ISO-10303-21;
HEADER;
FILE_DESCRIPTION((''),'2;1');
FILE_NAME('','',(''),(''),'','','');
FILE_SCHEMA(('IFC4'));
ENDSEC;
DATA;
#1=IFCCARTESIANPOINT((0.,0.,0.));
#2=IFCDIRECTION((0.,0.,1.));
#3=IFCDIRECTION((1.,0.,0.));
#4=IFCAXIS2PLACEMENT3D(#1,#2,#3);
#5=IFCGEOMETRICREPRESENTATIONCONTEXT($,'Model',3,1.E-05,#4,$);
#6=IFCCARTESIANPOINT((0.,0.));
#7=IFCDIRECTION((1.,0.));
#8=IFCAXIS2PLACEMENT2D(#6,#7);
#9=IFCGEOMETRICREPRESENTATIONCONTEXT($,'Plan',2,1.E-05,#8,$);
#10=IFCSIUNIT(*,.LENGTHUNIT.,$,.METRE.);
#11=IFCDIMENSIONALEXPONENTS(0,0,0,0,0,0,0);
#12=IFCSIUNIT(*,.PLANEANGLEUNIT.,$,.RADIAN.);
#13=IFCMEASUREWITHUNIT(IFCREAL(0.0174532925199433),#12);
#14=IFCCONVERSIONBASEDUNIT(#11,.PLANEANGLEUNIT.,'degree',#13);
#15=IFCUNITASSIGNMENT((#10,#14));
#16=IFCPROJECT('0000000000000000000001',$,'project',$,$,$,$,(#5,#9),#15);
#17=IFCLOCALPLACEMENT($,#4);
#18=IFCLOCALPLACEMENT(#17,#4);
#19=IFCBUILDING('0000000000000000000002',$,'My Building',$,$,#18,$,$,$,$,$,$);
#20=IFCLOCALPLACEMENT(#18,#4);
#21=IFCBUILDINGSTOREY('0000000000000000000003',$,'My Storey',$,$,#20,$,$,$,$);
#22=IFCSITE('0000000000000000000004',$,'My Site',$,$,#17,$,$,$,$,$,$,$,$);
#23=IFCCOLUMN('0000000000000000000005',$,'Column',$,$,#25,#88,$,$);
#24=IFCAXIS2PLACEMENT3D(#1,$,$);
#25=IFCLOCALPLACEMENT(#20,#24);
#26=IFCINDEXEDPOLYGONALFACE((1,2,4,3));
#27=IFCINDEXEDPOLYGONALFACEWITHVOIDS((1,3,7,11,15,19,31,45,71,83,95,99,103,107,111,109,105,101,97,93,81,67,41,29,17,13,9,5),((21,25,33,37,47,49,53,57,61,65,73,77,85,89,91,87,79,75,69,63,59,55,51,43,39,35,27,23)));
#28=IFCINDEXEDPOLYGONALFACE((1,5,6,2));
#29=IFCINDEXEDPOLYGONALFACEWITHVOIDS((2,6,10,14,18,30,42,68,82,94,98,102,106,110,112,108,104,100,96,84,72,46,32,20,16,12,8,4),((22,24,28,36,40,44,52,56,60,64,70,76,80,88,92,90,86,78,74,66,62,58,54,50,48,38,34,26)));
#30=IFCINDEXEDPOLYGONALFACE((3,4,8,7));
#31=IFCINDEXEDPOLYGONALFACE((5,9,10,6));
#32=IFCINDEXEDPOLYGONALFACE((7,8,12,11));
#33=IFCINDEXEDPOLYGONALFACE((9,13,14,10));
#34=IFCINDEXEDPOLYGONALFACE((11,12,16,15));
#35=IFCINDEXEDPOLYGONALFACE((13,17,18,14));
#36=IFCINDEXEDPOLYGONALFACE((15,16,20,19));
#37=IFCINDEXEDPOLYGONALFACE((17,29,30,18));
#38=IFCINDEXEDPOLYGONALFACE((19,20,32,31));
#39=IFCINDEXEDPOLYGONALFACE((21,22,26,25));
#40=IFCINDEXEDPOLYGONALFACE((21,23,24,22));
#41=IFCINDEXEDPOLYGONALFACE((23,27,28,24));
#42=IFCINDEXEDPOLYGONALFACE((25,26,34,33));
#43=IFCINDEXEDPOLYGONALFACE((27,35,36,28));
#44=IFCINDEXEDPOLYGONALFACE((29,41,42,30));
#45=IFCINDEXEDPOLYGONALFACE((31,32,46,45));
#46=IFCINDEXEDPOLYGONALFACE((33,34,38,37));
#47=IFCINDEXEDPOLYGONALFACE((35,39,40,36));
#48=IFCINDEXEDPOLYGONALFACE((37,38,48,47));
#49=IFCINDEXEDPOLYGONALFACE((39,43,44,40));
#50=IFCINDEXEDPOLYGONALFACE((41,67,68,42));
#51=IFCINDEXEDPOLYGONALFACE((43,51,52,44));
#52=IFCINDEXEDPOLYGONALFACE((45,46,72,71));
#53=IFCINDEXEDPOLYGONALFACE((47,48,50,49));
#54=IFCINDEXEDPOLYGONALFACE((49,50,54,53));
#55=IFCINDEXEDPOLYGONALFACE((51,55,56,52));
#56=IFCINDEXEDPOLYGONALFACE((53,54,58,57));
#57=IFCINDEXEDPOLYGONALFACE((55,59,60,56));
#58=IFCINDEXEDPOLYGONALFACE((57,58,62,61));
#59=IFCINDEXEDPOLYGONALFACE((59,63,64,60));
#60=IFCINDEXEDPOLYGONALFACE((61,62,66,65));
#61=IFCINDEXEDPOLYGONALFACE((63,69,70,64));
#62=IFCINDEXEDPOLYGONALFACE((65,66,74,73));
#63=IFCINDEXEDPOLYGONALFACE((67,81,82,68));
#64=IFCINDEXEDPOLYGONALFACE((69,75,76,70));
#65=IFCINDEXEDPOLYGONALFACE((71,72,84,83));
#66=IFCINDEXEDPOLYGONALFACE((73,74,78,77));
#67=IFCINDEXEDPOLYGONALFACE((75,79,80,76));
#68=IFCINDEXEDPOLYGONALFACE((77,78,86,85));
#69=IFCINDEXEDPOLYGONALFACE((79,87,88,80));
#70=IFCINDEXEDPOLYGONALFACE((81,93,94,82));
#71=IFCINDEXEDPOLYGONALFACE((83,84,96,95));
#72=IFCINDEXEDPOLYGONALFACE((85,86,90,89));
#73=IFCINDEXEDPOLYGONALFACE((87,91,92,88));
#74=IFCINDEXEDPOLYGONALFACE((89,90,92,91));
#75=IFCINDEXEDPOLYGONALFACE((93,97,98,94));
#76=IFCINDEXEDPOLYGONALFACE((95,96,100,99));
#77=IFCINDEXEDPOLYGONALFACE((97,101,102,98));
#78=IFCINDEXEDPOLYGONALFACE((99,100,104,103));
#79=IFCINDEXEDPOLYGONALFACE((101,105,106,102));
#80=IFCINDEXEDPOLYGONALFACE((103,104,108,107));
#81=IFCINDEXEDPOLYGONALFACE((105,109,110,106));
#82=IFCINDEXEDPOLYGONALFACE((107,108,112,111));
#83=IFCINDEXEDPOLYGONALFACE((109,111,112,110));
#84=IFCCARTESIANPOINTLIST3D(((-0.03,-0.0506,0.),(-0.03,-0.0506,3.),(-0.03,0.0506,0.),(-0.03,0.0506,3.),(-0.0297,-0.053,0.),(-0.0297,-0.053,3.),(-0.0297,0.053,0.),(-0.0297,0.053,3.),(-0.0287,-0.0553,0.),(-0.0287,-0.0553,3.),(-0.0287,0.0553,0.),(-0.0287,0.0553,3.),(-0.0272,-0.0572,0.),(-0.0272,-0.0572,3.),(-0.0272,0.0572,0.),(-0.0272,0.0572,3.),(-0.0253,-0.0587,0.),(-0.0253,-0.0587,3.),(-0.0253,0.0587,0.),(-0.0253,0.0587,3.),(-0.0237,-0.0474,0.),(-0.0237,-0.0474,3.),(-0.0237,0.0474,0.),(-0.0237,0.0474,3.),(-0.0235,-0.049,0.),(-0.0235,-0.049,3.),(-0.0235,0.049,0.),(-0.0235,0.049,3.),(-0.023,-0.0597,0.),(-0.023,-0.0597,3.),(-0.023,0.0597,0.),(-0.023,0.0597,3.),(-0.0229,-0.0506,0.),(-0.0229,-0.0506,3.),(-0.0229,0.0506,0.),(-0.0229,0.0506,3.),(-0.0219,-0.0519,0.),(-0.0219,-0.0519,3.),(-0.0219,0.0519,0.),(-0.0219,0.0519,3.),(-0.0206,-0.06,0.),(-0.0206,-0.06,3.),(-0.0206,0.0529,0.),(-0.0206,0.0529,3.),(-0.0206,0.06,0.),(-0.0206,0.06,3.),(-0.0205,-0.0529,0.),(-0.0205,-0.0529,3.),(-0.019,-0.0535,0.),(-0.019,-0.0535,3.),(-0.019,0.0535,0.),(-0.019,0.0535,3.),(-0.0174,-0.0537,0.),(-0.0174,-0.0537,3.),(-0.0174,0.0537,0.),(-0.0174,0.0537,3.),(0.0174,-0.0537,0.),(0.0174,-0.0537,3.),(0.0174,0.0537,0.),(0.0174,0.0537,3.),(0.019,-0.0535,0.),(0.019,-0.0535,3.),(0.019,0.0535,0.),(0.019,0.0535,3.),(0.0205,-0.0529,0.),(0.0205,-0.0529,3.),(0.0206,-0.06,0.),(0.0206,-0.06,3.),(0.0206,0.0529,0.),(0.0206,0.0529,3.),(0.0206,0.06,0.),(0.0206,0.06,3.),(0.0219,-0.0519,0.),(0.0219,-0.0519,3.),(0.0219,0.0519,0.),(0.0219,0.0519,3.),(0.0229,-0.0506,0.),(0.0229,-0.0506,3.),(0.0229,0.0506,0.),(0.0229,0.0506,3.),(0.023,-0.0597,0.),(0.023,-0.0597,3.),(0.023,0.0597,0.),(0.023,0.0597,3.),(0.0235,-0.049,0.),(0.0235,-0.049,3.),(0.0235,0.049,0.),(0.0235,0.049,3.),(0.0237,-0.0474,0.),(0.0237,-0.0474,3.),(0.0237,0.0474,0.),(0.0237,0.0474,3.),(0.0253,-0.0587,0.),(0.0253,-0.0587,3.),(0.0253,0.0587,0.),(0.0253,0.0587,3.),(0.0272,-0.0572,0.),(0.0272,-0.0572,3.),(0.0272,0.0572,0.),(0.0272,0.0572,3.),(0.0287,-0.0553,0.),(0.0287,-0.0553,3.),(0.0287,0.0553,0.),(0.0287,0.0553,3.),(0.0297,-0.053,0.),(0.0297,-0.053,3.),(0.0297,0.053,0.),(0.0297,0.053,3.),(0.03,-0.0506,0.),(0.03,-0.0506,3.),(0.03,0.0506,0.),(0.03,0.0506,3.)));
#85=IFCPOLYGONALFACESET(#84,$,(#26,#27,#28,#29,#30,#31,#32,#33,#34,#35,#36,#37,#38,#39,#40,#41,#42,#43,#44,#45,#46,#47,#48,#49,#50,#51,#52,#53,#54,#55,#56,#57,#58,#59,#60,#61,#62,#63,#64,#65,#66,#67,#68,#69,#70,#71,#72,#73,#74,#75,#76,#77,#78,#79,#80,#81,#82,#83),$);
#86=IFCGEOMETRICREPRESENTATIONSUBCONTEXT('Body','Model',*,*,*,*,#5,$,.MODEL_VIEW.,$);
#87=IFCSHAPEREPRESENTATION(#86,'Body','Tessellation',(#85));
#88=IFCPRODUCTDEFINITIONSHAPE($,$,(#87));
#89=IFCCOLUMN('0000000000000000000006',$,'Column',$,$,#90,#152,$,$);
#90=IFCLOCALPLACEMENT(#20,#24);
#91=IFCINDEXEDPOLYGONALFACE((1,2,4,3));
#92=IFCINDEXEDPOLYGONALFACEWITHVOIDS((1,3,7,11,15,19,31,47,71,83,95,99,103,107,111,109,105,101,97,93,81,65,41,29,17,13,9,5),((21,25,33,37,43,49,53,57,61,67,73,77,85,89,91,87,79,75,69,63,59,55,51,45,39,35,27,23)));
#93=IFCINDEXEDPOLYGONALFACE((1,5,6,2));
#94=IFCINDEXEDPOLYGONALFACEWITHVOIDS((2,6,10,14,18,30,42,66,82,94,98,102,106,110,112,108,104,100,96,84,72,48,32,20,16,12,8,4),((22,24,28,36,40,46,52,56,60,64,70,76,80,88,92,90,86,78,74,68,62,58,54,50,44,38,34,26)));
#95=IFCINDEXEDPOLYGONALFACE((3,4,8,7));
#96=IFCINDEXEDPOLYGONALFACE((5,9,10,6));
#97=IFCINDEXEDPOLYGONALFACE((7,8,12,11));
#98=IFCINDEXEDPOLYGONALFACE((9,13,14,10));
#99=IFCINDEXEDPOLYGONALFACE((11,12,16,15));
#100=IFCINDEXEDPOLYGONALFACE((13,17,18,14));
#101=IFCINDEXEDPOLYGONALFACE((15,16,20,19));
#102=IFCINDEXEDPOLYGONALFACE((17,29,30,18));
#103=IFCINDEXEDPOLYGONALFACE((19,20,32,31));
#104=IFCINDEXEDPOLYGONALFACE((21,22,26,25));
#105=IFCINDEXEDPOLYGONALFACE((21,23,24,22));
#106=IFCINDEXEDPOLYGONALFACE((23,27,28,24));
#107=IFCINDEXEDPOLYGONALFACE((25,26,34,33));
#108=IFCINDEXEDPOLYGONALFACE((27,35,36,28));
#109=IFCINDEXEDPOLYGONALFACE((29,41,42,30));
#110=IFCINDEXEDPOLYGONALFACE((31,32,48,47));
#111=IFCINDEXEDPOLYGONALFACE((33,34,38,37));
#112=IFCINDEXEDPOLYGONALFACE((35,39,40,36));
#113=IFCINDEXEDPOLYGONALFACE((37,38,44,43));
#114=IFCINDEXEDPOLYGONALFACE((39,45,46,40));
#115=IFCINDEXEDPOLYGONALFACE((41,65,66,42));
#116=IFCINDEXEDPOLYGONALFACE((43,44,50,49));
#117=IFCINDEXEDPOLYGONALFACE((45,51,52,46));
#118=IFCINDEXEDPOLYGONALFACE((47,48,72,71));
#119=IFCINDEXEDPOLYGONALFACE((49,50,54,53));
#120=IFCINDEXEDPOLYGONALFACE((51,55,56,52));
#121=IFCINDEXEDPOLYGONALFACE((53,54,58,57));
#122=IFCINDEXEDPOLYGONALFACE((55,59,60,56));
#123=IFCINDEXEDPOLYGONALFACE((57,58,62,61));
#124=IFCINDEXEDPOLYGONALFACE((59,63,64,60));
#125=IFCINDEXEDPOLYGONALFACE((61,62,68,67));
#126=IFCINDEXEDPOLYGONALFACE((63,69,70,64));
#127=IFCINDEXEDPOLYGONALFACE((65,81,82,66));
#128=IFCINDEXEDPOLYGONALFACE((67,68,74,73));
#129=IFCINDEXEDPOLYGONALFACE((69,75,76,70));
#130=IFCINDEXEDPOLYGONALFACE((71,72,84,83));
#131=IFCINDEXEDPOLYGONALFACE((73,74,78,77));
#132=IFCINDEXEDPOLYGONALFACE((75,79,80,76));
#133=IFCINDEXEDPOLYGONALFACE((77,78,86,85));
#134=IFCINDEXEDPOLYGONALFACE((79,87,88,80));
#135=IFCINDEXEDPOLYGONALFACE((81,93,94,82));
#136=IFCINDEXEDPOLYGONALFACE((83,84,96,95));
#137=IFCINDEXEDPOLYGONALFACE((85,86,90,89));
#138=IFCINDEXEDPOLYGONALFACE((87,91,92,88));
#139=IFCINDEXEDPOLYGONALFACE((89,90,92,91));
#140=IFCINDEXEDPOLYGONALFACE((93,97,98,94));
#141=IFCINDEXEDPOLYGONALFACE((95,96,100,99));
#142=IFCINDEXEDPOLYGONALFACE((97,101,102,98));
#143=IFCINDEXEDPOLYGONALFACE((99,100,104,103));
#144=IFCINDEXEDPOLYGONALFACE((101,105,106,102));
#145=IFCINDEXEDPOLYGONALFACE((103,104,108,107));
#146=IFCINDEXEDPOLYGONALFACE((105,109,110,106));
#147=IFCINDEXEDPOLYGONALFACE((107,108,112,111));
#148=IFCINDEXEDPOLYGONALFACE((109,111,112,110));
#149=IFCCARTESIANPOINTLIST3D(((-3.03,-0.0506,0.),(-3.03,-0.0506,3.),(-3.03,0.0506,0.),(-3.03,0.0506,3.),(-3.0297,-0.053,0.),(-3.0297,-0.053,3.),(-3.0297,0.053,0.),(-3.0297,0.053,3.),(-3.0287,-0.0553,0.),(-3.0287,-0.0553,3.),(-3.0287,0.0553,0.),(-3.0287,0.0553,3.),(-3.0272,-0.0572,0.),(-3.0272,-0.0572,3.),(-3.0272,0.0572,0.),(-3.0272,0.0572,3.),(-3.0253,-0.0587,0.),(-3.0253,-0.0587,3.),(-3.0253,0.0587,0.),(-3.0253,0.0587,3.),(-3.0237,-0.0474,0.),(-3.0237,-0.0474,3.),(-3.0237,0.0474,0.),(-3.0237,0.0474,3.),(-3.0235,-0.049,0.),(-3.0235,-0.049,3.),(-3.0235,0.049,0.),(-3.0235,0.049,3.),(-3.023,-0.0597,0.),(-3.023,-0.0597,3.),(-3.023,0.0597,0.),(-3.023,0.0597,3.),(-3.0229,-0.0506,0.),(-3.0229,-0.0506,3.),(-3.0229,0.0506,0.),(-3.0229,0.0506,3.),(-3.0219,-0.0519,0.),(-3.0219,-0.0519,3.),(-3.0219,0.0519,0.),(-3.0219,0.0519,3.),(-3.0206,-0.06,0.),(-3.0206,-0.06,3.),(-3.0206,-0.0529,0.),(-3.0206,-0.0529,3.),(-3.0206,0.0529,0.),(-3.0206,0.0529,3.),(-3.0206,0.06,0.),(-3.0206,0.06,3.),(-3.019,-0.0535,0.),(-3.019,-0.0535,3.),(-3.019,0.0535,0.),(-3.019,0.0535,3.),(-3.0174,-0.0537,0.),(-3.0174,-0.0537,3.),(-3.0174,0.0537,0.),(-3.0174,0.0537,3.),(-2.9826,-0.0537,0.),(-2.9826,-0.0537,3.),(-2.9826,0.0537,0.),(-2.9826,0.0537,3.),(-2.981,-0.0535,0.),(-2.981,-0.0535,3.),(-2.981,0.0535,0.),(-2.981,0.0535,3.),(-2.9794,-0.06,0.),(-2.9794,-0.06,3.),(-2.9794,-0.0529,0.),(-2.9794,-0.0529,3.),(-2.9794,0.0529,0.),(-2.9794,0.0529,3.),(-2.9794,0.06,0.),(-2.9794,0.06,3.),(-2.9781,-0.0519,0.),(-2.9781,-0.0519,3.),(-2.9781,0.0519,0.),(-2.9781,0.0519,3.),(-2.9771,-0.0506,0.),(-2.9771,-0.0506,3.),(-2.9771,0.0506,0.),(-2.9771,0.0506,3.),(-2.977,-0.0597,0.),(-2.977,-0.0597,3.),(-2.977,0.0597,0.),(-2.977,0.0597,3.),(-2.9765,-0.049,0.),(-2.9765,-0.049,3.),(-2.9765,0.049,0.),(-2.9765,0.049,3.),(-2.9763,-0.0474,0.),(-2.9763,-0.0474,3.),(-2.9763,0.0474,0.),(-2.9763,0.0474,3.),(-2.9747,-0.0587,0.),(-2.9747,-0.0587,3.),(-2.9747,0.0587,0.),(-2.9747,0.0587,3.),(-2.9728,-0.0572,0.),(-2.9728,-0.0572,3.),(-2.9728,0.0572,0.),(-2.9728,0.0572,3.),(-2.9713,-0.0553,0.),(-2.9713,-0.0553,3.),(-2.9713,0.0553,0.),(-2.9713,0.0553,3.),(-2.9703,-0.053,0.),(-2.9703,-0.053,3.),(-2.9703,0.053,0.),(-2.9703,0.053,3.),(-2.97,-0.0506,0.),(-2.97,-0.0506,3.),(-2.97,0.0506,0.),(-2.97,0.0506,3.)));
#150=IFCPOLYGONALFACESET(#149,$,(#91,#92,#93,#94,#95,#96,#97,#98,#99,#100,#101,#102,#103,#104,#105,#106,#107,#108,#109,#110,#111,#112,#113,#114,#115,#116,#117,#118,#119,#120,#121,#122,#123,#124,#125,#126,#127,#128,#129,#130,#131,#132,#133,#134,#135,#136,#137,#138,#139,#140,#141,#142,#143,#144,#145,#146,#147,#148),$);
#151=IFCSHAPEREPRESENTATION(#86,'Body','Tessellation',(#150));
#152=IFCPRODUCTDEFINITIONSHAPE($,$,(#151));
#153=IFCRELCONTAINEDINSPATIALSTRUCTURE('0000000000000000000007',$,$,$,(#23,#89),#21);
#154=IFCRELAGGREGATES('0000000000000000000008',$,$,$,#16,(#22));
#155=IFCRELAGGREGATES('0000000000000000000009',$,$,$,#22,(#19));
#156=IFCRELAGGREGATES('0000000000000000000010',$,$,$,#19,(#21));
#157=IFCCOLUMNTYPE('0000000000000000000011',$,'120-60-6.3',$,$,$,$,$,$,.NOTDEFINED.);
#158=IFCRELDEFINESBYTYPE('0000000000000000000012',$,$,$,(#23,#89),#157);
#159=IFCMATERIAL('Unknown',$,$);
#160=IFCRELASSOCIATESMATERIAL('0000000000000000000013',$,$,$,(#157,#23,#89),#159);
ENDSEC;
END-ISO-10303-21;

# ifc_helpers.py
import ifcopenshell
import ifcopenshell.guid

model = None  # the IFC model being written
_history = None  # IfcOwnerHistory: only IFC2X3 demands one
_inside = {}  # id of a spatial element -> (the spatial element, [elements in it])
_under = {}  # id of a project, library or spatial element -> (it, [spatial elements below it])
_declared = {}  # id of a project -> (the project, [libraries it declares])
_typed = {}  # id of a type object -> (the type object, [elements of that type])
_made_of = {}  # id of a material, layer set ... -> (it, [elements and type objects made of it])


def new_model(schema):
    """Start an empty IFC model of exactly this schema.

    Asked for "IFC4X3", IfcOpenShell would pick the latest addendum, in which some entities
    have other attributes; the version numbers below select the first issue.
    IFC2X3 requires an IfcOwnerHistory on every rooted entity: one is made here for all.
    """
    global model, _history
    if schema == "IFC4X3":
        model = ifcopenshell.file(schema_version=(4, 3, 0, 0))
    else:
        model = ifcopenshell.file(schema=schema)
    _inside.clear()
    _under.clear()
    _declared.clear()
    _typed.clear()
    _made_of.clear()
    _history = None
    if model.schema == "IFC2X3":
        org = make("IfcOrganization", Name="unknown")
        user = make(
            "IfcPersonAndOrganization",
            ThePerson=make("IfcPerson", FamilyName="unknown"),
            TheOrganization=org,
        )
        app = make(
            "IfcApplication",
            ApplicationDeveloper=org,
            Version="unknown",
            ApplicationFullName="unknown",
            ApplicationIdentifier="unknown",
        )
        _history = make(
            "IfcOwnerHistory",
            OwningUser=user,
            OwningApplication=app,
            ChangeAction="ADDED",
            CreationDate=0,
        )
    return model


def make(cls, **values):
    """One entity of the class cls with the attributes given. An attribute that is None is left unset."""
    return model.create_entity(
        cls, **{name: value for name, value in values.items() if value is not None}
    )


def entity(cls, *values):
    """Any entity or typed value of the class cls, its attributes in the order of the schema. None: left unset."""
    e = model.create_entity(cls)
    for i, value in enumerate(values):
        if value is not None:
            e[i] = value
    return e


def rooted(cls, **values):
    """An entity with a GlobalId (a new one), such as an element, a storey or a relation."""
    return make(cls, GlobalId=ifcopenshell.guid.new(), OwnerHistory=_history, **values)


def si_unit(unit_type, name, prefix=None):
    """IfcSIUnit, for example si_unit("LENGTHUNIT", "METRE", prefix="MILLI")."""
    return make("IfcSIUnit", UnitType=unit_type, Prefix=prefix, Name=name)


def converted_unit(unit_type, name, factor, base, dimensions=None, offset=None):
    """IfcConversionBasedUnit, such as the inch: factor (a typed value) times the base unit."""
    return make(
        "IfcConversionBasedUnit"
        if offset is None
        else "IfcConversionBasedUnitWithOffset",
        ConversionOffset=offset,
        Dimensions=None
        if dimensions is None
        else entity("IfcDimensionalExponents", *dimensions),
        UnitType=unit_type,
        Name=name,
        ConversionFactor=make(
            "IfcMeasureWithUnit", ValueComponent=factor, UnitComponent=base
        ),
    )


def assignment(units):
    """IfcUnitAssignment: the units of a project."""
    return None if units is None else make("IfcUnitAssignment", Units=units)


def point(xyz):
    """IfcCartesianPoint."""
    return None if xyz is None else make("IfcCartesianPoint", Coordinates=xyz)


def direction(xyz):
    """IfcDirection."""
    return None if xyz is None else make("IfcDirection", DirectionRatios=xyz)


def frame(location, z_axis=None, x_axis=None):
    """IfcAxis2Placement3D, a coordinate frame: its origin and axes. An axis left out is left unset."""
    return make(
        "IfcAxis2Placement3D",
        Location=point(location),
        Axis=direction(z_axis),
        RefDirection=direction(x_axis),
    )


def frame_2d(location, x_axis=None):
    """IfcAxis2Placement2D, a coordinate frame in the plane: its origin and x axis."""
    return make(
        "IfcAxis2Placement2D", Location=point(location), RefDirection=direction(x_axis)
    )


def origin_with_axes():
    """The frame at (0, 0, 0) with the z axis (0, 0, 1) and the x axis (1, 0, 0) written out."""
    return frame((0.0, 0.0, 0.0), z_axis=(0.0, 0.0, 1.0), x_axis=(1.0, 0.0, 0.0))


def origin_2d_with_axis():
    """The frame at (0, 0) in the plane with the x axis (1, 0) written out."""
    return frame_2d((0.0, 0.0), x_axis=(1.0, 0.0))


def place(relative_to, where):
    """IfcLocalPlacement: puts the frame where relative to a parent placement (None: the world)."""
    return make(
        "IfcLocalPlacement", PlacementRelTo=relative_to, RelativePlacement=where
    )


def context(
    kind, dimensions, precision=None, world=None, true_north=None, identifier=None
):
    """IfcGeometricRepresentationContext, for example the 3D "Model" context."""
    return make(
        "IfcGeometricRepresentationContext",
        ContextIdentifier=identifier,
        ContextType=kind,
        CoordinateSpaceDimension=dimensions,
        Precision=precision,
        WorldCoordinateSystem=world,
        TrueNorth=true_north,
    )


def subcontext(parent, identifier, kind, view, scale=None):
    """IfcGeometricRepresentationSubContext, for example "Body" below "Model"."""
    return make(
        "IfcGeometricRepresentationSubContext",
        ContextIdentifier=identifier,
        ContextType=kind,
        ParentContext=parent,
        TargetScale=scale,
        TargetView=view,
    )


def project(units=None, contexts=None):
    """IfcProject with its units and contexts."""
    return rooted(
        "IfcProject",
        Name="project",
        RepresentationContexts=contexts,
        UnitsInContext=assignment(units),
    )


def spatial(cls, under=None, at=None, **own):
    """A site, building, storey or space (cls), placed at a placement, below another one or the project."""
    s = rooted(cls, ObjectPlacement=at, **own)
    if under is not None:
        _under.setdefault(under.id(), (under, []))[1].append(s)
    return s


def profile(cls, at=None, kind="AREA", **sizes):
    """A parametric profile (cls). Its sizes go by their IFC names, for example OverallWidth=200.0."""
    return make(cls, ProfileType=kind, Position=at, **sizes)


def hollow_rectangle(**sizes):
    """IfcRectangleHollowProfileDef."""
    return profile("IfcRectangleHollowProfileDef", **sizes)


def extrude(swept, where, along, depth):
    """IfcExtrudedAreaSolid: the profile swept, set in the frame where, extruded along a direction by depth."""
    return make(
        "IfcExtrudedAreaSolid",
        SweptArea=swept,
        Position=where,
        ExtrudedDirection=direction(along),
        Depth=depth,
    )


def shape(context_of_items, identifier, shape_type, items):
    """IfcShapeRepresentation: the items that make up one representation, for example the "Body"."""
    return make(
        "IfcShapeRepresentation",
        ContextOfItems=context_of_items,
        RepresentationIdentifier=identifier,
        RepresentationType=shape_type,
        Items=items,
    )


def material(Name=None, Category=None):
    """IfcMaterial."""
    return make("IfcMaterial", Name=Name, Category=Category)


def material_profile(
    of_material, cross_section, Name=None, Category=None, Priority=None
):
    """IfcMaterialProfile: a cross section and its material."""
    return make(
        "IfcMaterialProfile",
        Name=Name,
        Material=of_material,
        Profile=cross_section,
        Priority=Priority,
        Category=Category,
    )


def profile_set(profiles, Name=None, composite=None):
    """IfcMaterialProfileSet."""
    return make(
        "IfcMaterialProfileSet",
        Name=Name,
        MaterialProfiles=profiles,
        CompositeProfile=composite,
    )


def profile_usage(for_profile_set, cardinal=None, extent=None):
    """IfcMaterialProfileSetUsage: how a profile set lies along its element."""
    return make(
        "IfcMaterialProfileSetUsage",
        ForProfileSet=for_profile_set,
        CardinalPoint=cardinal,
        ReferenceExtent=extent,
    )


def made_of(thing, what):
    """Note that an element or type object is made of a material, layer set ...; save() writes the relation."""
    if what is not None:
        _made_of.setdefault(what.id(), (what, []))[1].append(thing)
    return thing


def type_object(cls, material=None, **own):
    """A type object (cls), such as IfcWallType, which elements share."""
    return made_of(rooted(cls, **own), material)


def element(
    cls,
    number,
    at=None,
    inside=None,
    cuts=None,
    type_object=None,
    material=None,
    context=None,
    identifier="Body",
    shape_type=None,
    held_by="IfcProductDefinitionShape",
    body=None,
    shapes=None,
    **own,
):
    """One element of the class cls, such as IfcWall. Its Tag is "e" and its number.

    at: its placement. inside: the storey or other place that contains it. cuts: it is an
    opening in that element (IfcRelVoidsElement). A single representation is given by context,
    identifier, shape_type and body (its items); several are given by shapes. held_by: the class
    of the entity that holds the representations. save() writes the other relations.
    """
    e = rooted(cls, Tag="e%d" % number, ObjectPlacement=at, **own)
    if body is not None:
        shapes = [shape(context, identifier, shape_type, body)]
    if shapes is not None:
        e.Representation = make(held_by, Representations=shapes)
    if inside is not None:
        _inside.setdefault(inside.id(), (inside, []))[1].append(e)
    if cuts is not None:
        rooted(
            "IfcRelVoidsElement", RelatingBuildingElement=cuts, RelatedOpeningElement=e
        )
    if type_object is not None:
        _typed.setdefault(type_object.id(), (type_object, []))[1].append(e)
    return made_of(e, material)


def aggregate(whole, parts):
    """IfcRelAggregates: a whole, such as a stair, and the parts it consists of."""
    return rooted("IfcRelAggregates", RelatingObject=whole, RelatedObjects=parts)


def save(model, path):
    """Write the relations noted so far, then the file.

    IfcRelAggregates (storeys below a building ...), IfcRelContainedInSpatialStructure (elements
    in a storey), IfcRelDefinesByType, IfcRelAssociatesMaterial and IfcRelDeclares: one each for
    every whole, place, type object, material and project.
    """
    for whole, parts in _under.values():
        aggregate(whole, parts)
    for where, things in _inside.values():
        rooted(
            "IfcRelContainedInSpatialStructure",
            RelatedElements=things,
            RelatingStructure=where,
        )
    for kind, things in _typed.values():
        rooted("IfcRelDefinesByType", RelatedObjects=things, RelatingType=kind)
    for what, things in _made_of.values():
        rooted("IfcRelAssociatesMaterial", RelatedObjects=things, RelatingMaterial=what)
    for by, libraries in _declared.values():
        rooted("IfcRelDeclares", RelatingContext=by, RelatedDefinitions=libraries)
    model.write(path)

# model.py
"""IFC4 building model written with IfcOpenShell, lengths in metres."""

from ifc_helpers import new_model, entity, si_unit, converted_unit, frame, origin_with_axes, origin_2d_with_axis, place, context, subcontext, project, spatial, hollow_rectangle, extrude, material, material_profile, profile_set, profile_usage, type_object, element, save


model = new_model("IFC4")

# Units and contexts
model_context = context("Model", 3, precision=1e-05, world=origin_with_axes())
plan_context = context("Plan", 2, precision=1e-05, world=origin_2d_with_axis())
body_context = subcontext(model_context, "Body", "Model", "MODEL_VIEW")
ifc_project = project(units=[si_unit("LENGTHUNIT", "METRE"), converted_unit("PLANEANGLEUNIT", "degree", entity("IfcReal", 0.0174532925199433), si_unit("PLANEANGLEUNIT", "RADIAN"), dimensions=[0, 0, 0, 0, 0, 0, 0])], contexts=[model_context, plan_context])

# Site, building, storey
site_placement = place(None, origin_with_axes())
site = spatial("IfcSite", under=ifc_project, at=site_placement, Name="My Site")
building_placement = place(site_placement, origin_with_axes())
building = spatial("IfcBuilding", under=site, at=building_placement, Name="My Building")
storey_placement = place(building_placement, origin_with_axes())
storey = spatial("IfcBuildingStorey", under=building, at=storey_placement, Name="My Storey")

# Shared definitions
ifc_material = material(Name="Unknown")

# Columns
ifc_material_profile_1 = material_profile(ifc_material, hollow_rectangle(XDim=0.06, YDim=0.12, WallThickness=0.0063, InnerFilletRadius=0.0063, OuterFilletRadius=0.0095))
ifc_profile_set_1 = profile_set([ifc_material_profile_1])
ifc_profile_usage_1 = profile_usage(ifc_profile_set_1, cardinal=5)
column_type = type_object("IfcColumnType", Name="120-60-6.3", PredefinedType="NOTDEFINED", material=ifc_profile_set_1)
column_1_placement = place(storey_placement, origin_with_axes())
element("IfcColumn", 1, at=column_1_placement, inside=storey, type_object=column_type, material=ifc_profile_usage_1, Name="Column", context=body_context, shape_type="SweptSolid", body=[
    extrude(hollow_rectangle(XDim=0.06, YDim=0.12, WallThickness=0.0063, InnerFilletRadius=0.0063, OuterFilletRadius=0.0095), origin_with_axes(), (0.0, 0.0, 1.0), 3.0),
])
ifc_profile_usage_2 = profile_usage(ifc_profile_set_1, cardinal=5)
column_2_placement = place(storey_placement, frame((-3.0, 0.0, 0.0), z_axis=(0.0, 0.0, 1.0), x_axis=(1.0, 0.0, 0.0)))
element("IfcColumn", 2, at=column_2_placement, inside=storey, type_object=column_type, material=ifc_profile_usage_2, Name="Column", context=body_context, shape_type="SweptSolid", body=[
    extrude(hollow_rectangle(XDim=0.06, YDim=0.12, WallThickness=0.0063, InnerFilletRadius=0.0063, OuterFilletRadius=0.0095), origin_with_axes(), (0.0, 0.0, 1.0), 3.0),
])

save(model, "model.ifc")
